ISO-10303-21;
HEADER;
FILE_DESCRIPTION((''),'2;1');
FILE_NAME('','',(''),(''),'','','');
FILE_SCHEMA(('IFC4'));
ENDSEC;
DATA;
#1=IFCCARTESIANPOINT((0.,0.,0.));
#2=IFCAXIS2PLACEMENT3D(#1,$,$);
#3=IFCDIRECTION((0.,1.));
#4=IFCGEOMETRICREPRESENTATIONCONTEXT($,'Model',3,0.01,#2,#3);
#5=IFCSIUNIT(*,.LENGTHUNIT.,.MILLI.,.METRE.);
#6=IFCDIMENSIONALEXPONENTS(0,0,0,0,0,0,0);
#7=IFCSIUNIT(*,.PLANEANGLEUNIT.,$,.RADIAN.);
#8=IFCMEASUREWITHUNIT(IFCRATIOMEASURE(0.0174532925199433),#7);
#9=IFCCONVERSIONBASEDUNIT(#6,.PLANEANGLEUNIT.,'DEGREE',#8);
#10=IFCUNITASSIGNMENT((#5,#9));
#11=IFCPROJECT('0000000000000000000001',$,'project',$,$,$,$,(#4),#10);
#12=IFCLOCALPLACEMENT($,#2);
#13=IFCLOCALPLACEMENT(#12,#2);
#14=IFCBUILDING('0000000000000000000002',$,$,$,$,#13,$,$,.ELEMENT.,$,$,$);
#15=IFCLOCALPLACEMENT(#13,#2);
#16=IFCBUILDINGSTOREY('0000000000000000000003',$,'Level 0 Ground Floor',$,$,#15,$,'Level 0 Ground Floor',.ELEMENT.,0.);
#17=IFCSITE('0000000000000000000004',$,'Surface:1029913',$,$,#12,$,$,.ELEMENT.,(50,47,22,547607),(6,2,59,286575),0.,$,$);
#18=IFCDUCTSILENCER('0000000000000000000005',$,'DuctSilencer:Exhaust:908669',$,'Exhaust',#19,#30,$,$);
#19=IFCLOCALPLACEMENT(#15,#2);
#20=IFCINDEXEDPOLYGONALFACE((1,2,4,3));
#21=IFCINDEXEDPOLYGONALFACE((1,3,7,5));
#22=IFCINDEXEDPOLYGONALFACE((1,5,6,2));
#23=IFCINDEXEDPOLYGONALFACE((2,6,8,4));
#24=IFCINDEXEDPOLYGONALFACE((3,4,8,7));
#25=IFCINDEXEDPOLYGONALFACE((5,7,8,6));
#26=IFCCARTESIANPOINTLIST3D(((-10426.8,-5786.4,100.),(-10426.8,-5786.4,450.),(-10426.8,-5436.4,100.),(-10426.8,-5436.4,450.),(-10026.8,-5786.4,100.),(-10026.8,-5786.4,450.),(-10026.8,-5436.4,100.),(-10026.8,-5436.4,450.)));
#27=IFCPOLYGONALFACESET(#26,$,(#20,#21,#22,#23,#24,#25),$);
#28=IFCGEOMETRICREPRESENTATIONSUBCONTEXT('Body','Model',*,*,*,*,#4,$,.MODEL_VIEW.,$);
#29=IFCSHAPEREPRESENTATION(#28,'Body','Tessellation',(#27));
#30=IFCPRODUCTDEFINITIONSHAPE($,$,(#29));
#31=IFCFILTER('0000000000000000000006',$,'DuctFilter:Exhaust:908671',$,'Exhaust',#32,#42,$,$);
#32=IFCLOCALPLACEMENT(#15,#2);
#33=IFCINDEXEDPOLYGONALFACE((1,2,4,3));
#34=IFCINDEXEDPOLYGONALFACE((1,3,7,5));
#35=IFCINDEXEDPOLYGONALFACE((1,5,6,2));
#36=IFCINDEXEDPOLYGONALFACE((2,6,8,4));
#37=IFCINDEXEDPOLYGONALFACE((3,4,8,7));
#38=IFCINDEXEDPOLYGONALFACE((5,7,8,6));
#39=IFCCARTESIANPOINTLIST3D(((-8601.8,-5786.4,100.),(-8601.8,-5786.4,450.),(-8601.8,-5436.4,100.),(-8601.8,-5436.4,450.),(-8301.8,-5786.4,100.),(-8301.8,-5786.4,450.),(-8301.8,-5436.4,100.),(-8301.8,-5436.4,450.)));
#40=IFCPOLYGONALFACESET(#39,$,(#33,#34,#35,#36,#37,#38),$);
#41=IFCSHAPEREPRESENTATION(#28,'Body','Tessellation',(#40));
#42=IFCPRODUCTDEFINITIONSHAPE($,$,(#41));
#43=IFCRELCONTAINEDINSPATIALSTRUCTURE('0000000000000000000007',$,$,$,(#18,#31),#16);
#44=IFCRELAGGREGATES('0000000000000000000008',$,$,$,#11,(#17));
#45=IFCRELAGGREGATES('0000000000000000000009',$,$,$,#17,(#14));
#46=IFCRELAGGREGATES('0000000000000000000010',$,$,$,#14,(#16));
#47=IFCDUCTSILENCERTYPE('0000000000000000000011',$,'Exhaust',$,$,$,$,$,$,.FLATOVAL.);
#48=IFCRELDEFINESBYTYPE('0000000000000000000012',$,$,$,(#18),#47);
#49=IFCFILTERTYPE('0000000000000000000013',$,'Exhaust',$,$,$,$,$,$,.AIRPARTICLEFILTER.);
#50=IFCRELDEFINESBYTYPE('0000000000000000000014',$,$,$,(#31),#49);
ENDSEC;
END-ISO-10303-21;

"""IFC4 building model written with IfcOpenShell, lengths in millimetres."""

from ifc_helpers import new_model, entity, si_unit, converted_unit, direction, frame, frame_2d, origin, origin_2d_with_axis, place, context, subcontext, project, spatial, rectangle, extrude, source, transform, mapped, type_object, type_shapes, element, save


model = new_model("IFC4")

# Units and contexts
model_context = context("Model", 3, precision=0.01, world=origin(), true_north=direction((0.0, 1.0)))
body_context = subcontext(model_context, "Body", "Model", "MODEL_VIEW")
ifc_project = project(units=[si_unit("LENGTHUNIT", "METRE", prefix="MILLI"), converted_unit("PLANEANGLEUNIT", "DEGREE", entity("IfcRatioMeasure", 0.0174532925199433), si_unit("PLANEANGLEUNIT", "RADIAN"), dimensions=[0, 0, 0, 0, 0, 0, 0])], contexts=[model_context])

# Site, building, storey
site_placement = place(None, origin())
site = spatial("IfcSite", under=ifc_project, at=site_placement, Name="Surface:1029913", CompositionType="ELEMENT", RefLatitude=(50, 47, 22, 547607), RefLongitude=(6, 2, 59, 286575), RefElevation=0.0)
building_placement = place(site_placement, origin())
building = spatial("IfcBuilding", under=site, at=building_placement, CompositionType="ELEMENT")
storey_placement = place(building_placement, origin())
storey = spatial("IfcBuildingStorey", under=building, at=storey_placement, Name="Level 0 Ground Floor", LongName="Level 0 Ground Floor", CompositionType="ELEMENT", Elevation=0.0)

# Duct silencer
duct_silencer_type_1 = type_object("IfcDuctSilencerType", Name="Exhaust", PredefinedType="FLATOVAL")
shared_shape_1 = source(origin(), body_context, "Body", "SweptSolid", [
    extrude(rectangle(XDim=400.0, YDim=350.0, at=frame_2d((0.0, 0.0), x_axis=(1.0, 0.0))), frame((0.0, 0.0, -175.0), z_axis=(0.0, 0.0, 1.0), x_axis=(-1.0, 0.0, 0.0)), (0.0, 0.0, 1.0), 350.0),
])
type_shapes(duct_silencer_type_1, [shared_shape_1])
duct_silencer_1_placement = place(storey_placement, frame((-10226.8, -5611.4, 275.0), z_axis=(0.0, 0.0, 1.0), x_axis=(-1.0, 0.0, 0.0)))
element("IfcDuctSilencer", 1, at=duct_silencer_1_placement, inside=storey, type_object=duct_silencer_type_1, Name="DuctSilencer:Exhaust:908669", ObjectType="Exhaust", context=body_context, shape_type="MappedRepresentation", body=[
    mapped(shared_shape_1, transform((0.0, 0.0, 0.0), scale=1.0)),
])

# Filter
filter_type_1 = type_object("IfcFilterType", Name="Exhaust", PredefinedType="AIRPARTICLEFILTER")
shared_shape_2 = source(origin(), body_context, "Body", "SweptSolid", [
    extrude(rectangle(XDim=300.0, YDim=350.0, at=origin_2d_with_axis()), frame((0.0, 0.0, -175.0), z_axis=(0.0, 0.0, 1.0), x_axis=(-1.0, 0.0, 0.0)), (0.0, 0.0, 1.0), 350.0),
])
type_shapes(filter_type_1, [shared_shape_2])
ifc_filter_placement = place(storey_placement, frame((-8451.8, -5611.4, 275.0), z_axis=(0.0, 0.0, 1.0), x_axis=(-1.0, 0.0, 0.0)))
element("IfcFilter", 2, at=ifc_filter_placement, inside=storey, type_object=filter_type_1, Name="DuctFilter:Exhaust:908671", ObjectType="Exhaust", context=body_context, shape_type="MappedRepresentation", body=[
    mapped(shared_shape_2, transform((0.0, 0.0, 0.0), scale=1.0)),
])

save(model, "model.ifc")
